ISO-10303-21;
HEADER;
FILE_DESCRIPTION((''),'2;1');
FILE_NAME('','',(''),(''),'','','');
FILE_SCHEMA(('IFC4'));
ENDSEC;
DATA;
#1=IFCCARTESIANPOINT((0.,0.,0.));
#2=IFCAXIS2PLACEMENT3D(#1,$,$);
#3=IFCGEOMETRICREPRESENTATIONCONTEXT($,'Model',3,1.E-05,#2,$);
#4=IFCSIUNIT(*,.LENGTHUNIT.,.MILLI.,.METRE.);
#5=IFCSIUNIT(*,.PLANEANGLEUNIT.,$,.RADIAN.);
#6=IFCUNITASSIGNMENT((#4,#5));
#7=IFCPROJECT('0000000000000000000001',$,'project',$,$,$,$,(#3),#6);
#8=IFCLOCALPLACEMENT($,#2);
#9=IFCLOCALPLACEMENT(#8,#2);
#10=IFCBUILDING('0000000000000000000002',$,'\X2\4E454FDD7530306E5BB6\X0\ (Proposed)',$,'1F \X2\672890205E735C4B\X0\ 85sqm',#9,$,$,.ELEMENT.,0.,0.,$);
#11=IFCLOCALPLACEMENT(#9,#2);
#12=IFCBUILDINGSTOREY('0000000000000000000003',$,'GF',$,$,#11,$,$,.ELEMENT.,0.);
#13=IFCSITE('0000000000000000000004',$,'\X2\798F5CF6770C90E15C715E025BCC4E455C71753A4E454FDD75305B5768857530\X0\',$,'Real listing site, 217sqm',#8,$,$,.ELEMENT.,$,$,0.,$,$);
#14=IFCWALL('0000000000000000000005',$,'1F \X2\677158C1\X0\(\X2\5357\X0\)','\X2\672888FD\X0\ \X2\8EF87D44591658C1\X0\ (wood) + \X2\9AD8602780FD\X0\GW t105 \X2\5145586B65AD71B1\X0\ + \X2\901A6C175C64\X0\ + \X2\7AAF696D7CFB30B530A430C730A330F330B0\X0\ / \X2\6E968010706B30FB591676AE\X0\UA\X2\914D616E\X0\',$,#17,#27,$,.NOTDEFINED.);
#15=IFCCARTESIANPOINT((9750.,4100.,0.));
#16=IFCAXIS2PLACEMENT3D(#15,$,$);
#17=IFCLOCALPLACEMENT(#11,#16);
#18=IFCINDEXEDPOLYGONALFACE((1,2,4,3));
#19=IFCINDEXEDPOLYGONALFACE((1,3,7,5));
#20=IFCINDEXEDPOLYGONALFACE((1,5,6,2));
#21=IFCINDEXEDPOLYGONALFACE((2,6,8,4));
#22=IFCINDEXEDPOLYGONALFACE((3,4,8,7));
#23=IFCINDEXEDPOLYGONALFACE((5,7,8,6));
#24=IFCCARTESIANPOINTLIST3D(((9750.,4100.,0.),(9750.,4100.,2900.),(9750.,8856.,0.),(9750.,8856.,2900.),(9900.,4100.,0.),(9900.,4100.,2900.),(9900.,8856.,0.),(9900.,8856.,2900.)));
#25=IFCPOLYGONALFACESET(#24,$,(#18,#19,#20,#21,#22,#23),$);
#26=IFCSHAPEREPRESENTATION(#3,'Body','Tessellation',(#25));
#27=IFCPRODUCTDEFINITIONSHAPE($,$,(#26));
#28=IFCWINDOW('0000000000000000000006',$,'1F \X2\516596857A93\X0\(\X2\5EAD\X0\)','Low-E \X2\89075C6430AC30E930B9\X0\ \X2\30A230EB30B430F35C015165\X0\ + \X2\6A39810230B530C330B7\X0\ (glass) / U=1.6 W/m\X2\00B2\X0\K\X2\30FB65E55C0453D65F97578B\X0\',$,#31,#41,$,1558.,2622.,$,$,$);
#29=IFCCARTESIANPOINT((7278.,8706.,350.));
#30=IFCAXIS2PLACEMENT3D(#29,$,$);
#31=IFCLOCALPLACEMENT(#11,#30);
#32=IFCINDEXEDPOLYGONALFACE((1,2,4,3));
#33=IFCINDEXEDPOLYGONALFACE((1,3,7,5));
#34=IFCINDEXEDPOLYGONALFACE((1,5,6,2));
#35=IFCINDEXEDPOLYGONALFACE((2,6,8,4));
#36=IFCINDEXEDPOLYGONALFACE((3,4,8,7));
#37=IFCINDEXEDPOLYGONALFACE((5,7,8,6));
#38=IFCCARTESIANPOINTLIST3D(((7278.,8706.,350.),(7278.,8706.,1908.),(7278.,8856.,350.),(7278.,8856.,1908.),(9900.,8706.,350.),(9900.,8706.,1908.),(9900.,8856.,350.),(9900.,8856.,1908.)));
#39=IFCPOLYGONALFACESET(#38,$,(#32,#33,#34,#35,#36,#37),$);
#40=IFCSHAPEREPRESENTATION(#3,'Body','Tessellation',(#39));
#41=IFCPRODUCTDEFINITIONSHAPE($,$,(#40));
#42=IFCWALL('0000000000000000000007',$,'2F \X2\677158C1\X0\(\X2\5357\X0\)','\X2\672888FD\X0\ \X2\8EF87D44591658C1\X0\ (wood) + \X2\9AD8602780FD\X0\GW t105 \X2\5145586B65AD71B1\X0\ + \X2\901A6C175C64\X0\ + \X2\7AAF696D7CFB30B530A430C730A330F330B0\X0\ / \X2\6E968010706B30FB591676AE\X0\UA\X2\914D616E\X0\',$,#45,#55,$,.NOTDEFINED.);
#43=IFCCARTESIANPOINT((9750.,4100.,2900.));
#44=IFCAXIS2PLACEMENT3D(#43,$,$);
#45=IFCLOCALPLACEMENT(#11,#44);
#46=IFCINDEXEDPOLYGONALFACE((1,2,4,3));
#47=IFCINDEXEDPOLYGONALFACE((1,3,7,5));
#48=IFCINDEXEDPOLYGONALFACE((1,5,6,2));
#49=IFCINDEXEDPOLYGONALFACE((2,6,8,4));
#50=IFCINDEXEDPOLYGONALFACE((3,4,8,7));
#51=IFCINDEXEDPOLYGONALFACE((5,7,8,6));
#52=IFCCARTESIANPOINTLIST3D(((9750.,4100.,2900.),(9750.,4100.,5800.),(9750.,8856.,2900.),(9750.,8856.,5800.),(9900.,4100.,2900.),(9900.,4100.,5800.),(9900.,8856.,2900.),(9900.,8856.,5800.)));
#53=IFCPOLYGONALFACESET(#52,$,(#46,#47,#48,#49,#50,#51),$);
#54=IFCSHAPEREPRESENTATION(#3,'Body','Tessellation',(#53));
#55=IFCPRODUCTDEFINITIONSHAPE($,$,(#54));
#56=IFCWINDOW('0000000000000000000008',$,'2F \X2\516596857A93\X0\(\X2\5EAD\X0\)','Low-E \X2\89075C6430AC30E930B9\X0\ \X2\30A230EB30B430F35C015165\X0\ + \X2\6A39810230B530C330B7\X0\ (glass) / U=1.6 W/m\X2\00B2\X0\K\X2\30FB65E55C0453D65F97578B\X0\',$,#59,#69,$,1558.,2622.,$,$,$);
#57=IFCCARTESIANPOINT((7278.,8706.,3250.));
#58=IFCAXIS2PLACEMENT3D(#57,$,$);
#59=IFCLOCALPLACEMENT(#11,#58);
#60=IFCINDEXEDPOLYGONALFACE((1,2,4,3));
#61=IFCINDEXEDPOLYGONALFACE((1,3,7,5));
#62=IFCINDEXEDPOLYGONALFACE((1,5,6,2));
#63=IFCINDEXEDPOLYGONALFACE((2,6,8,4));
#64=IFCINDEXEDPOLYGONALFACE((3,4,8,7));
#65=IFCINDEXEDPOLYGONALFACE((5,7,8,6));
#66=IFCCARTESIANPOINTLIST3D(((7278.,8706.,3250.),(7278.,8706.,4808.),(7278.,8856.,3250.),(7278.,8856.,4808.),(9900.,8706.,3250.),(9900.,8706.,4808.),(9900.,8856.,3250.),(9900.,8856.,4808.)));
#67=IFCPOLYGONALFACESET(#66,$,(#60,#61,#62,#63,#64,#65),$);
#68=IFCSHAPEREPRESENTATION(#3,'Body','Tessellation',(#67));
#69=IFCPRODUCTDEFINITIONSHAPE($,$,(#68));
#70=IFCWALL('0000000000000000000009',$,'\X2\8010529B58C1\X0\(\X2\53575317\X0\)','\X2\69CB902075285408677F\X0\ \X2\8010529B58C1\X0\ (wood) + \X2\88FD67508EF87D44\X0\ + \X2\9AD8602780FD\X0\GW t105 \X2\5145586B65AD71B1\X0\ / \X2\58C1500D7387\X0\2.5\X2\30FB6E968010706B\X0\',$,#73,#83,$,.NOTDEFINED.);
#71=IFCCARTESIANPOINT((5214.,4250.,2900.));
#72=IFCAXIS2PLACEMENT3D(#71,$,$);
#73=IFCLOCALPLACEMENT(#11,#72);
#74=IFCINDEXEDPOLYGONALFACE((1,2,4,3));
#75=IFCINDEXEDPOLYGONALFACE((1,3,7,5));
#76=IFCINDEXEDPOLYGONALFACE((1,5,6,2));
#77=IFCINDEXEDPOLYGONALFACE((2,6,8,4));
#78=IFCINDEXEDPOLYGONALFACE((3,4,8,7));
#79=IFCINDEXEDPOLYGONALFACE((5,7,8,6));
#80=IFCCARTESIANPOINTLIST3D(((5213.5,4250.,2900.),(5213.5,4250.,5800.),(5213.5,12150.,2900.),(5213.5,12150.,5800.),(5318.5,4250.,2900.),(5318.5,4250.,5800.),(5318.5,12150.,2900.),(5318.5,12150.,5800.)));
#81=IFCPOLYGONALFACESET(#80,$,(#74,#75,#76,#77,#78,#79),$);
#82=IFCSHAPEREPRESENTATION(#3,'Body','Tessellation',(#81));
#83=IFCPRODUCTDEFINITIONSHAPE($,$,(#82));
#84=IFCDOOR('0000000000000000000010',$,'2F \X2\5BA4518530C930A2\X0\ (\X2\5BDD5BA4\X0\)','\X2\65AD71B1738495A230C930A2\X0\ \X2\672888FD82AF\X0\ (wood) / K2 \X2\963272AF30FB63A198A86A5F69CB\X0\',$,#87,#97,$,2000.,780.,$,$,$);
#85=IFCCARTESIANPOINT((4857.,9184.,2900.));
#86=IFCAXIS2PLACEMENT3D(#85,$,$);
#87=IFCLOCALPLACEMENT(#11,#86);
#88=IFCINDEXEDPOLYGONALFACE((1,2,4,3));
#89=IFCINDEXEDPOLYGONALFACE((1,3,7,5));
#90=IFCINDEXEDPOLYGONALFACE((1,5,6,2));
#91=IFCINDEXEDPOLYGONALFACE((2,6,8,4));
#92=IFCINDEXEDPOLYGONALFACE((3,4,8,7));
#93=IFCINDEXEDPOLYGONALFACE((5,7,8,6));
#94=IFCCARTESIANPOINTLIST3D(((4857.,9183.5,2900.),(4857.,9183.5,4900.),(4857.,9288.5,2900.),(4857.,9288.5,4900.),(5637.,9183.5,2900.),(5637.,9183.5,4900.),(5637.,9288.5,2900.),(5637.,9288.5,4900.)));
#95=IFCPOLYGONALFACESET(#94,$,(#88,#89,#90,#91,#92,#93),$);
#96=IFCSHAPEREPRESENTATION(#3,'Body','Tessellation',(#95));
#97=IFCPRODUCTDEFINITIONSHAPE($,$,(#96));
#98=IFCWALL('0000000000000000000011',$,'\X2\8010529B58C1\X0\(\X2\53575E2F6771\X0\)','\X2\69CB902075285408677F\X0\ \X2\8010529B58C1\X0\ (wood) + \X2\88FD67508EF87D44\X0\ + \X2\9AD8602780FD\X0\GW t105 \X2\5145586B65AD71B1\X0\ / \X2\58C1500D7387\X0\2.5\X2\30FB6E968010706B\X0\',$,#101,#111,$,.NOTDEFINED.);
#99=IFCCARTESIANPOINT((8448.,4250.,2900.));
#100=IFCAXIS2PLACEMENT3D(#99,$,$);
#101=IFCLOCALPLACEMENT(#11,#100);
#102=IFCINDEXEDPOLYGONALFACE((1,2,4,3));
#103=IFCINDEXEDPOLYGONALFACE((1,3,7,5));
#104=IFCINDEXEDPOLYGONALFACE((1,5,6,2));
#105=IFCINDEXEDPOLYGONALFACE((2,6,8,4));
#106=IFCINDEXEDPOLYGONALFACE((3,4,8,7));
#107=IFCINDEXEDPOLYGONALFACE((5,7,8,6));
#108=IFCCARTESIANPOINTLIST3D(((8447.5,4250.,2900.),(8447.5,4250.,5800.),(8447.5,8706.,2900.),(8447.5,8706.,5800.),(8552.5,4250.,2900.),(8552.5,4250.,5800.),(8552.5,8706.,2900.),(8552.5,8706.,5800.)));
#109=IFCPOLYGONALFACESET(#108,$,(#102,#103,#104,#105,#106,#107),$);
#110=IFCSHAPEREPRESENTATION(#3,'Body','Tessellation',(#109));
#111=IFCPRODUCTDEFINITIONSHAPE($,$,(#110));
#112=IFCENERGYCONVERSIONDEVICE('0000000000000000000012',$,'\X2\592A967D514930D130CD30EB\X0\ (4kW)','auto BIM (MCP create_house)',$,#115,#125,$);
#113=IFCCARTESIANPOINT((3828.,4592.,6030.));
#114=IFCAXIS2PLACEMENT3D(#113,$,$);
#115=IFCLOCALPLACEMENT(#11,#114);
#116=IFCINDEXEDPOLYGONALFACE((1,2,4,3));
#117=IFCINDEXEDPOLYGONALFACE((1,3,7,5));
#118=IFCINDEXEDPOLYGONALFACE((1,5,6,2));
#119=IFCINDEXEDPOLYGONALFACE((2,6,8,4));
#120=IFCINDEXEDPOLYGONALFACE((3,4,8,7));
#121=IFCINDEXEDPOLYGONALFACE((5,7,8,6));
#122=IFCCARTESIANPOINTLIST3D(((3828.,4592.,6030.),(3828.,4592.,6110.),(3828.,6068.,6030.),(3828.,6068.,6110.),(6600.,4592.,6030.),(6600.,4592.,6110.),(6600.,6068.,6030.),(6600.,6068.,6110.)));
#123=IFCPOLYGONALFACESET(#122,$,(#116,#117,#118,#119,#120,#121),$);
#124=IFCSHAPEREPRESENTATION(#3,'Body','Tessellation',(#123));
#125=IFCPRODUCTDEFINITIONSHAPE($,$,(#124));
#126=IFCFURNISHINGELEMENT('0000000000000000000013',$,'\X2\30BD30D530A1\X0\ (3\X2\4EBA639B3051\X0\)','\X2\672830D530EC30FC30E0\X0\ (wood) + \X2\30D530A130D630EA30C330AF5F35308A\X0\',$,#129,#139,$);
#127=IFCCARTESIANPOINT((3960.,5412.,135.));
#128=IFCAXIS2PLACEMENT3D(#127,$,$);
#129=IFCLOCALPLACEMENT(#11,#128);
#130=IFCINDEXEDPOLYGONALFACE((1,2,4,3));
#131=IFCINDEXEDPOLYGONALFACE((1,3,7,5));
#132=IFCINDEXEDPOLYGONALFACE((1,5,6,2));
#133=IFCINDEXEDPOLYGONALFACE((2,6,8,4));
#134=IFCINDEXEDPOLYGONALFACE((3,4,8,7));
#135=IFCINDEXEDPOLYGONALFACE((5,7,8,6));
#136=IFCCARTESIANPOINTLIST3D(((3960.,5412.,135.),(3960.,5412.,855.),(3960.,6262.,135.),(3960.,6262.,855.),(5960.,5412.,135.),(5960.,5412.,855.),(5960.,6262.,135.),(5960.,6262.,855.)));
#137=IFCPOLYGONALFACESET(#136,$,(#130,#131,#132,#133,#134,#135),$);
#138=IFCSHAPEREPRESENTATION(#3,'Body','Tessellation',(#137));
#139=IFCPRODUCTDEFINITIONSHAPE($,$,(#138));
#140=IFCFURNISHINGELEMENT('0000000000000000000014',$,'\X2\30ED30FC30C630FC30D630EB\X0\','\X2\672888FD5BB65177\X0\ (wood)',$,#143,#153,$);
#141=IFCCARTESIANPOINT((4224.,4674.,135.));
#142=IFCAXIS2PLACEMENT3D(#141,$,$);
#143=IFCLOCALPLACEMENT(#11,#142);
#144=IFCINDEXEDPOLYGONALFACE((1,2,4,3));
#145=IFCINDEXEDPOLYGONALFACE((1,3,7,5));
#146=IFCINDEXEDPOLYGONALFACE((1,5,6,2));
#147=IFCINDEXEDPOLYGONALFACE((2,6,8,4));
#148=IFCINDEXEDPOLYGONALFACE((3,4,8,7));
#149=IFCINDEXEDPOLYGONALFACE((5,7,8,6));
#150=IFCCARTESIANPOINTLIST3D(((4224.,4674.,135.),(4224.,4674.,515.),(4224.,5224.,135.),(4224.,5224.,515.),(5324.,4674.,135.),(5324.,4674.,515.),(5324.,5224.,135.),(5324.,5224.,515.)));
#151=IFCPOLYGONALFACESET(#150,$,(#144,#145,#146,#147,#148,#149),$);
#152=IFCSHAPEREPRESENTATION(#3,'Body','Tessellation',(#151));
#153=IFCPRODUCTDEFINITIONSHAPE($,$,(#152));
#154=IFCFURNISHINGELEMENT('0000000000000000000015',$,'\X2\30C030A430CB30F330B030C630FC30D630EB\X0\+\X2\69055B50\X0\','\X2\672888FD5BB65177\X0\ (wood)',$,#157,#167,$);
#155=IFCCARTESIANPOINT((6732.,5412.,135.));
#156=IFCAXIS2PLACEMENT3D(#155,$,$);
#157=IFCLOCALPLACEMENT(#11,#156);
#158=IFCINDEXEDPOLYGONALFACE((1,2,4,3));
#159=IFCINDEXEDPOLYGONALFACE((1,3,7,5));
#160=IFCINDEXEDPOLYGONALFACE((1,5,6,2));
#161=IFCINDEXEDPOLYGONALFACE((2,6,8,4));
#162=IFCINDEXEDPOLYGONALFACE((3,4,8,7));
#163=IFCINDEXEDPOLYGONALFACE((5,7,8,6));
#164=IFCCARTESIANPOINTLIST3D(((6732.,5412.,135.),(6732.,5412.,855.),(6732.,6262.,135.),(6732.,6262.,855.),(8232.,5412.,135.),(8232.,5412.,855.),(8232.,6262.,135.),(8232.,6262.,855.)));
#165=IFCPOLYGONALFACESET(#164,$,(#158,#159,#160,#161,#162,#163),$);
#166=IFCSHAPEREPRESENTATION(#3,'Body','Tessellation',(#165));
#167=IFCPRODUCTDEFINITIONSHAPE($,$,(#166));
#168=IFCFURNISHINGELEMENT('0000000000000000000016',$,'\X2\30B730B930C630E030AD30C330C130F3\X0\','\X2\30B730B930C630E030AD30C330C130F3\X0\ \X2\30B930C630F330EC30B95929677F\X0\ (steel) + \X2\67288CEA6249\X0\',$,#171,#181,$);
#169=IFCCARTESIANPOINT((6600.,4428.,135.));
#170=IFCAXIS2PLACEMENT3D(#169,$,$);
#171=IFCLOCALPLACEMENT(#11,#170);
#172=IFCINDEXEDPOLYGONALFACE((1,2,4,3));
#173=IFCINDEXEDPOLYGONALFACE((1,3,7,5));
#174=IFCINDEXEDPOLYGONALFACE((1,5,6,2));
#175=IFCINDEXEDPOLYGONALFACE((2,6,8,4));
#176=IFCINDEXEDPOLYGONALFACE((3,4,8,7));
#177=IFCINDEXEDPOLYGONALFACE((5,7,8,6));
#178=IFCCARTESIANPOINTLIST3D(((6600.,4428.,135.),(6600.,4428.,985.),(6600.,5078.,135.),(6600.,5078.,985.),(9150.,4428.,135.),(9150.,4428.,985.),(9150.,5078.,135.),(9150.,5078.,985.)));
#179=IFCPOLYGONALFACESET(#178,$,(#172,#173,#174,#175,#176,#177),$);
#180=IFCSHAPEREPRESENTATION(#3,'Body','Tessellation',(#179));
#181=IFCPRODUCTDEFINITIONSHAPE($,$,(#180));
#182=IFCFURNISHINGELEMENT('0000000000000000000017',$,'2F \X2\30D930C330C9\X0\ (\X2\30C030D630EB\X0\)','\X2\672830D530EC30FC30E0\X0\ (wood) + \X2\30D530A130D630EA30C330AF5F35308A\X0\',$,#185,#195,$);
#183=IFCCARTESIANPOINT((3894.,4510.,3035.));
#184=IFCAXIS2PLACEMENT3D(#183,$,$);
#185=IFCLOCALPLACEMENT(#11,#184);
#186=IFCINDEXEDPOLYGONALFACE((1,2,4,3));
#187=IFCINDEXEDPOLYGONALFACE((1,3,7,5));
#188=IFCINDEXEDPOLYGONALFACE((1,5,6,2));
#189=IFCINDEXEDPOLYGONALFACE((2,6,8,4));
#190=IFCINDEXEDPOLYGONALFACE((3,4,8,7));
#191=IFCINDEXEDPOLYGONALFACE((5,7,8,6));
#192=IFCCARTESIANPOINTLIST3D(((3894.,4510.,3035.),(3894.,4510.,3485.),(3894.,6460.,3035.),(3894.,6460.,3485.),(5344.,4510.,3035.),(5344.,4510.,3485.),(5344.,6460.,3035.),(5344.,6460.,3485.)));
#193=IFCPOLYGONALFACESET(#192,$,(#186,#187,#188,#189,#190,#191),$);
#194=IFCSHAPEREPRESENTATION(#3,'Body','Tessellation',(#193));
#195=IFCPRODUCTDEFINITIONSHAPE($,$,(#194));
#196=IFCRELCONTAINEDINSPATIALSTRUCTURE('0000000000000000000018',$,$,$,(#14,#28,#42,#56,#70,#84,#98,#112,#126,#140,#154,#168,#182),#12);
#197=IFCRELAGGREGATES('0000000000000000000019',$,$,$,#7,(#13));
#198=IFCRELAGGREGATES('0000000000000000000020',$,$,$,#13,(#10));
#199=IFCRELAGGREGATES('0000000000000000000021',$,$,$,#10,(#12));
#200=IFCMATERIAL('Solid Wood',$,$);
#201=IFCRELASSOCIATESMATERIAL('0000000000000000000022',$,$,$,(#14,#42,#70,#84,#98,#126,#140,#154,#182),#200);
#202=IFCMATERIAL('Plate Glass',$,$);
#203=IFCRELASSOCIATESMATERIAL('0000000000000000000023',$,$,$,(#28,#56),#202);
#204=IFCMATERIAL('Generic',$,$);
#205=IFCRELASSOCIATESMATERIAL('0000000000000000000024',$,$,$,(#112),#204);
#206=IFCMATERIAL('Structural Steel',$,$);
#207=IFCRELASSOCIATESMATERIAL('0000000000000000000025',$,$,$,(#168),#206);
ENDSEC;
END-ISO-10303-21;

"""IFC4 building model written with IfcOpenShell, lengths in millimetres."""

from ifc_helpers import new_model, si_unit, frame, frame_2d, origin, place, context, project, spatial, rectangle, extrude, material, element, fill, save


model = new_model("IFC4")

# Units and contexts
model_context = context("Model", 3, precision=1e-05, world=origin())
ifc_project = project(units=[si_unit("LENGTHUNIT", "METRE", prefix="MILLI"), si_unit("PLANEANGLEUNIT", "RADIAN")], contexts=[model_context])

# Site, building, storey
site_placement = place(None, origin())
site = spatial("IfcSite", under=ifc_project, at=site_placement, Name="福島県郡山市富久山町久保田字梅田", ObjectType="Real listing site, 217sqm", CompositionType="ELEMENT", RefElevation=0.0)
building_placement = place(site_placement, origin())
building = spatial("IfcBuilding", under=site, at=building_placement, Name="久保田の家 (Proposed)", ObjectType="1F 木造平屋 85sqm", CompositionType="ELEMENT", ElevationOfRefHeight=0.0, ElevationOfTerrain=0.0)
storey_placement = place(building_placement, origin())
storey = spatial("IfcBuildingStorey", under=building, at=storey_placement, Name="GF", CompositionType="ELEMENT", Elevation=0.0)

# Wall, opening, window
ifc_material_1 = material(Name="Solid Wood")
wall_1_placement = place(storey_placement, frame((9750.0, 4100.0, 0.0)))
wall_1 = element("IfcWall", 1, at=wall_1_placement, inside=storey, material=ifc_material_1, Name="1F 東壁(南)", Description="木製 軸組外壁 (wood) + 高性能GW t105 充填断熱 + 通気層 + 窯業系サイディング / 準耐火・外皮UA配慮", PredefinedType="NOTDEFINED", context=model_context, shape_type="SweptSolid", body=[
    extrude(rectangle(XDim=150.0, YDim=4756.0, at=frame_2d((75.0, 2378.0))), frame((9750.0, 4100.0, 0.0)), (0.0, 0.0, 1.0), 2900.0),
])
opening_1_placement = place(storey_placement, frame((7278.0, 8706.0, 350.0)))
opening_1 = element("IfcOpeningElement", 2, at=opening_1_placement, cuts=wall_1, PredefinedType="NOTDEFINED", context=model_context, shape_type="SweptSolid", body=[
    extrude(rectangle(XDim=2622.0, YDim=150.0, at=frame_2d((1311.0, 75.0))), frame((7278.0, 8706.0, 350.0)), (0.0, 0.0, 1.0), 1558.0),
])
ifc_material_2 = material(Name="Plate Glass")
window_1_placement = place(storey_placement, frame((7278.0, 8706.0, 350.0)))
window_1 = element("IfcWindow", 3, at=window_1_placement, inside=storey, material=ifc_material_2, Name="1F 入隅窓(庭)", Description="Low-E 複層ガラス アルゴン封入 + 樹脂サッシ (glass) / U=1.6 W/m²K・日射取得型", OverallHeight=1558.0, OverallWidth=2622.0, context=model_context, shape_type="SweptSolid", body=[
    extrude(rectangle(XDim=2622.0, YDim=150.0, at=frame_2d((1311.0, 75.0))), frame((7278.0, 8706.0, 350.0)), (0.0, 0.0, 1.0), 1558.0),
])
fill(opening_1, window_1)

# Wall, opening, window
wall_2_placement = place(storey_placement, frame((9750.0, 4100.0, 2900.0)))
wall_2 = element("IfcWall", 4, at=wall_2_placement, inside=storey, material=ifc_material_1, Name="2F 東壁(南)", Description="木製 軸組外壁 (wood) + 高性能GW t105 充填断熱 + 通気層 + 窯業系サイディング / 準耐火・外皮UA配慮", PredefinedType="NOTDEFINED", context=model_context, shape_type="SweptSolid", body=[
    extrude(rectangle(XDim=150.0, YDim=4756.0, at=frame_2d((75.0, 2378.0))), frame((9750.0, 4100.0, 2900.0)), (0.0, 0.0, 1.0), 2900.0),
])
opening_2_placement = place(storey_placement, frame((7278.0, 8706.0, 3250.0)))
opening_2 = element("IfcOpeningElement", 5, at=opening_2_placement, cuts=wall_2, PredefinedType="NOTDEFINED", context=model_context, shape_type="SweptSolid", body=[
    extrude(rectangle(XDim=2622.0, YDim=150.0, at=frame_2d((1311.0, 75.0))), frame((7278.0, 8706.0, 3250.0)), (0.0, 0.0, 1.0), 1558.0),
])
window_2_placement = place(storey_placement, frame((7278.0, 8706.0, 3250.0)))
window_2 = element("IfcWindow", 6, at=window_2_placement, inside=storey, material=ifc_material_2, Name="2F 入隅窓(庭)", Description="Low-E 複層ガラス アルゴン封入 + 樹脂サッシ (glass) / U=1.6 W/m²K・日射取得型", OverallHeight=1558.0, OverallWidth=2622.0, context=model_context, shape_type="SweptSolid", body=[
    extrude(rectangle(XDim=2622.0, YDim=150.0, at=frame_2d((1311.0, 75.0))), frame((7278.0, 8706.0, 3250.0)), (0.0, 0.0, 1.0), 1558.0),
])
fill(opening_2, window_2)

# Wall, opening, door
wall_3_placement = place(storey_placement, frame((5214.0, 4250.0, 2900.0)))
wall_3 = element("IfcWall", 7, at=wall_3_placement, inside=storey, material=ifc_material_1, Name="耐力壁(南北)", Description="構造用合板 耐力壁 (wood) + 製材軸組 + 高性能GW t105 充填断熱 / 壁倍率2.5・準耐火", PredefinedType="NOTDEFINED", context=model_context, shape_type="SweptSolid", body=[
    extrude(rectangle(XDim=105.0, YDim=7900.0, at=frame_2d((52.0, 3950.0))), frame((5214.0, 4250.0, 2900.0)), (0.0, 0.0, 1.0), 2900.0),
])
opening_3_placement = place(storey_placement, frame((4857.0, 9184.0, 2900.0)))
opening_3 = element("IfcOpeningElement", 8, at=opening_3_placement, cuts=wall_3, PredefinedType="NOTDEFINED", context=model_context, shape_type="SweptSolid", body=[
    extrude(rectangle(XDim=780.0, YDim=105.0, at=frame_2d((390.0, 52.0))), frame((4857.0, 9184.0, 2900.0)), (0.0, 0.0, 1.0), 2000.0),
])
door_1_placement = place(storey_placement, frame((4857.0, 9184.0, 2900.0)))
door_1 = element("IfcDoor", 9, at=door_1_placement, inside=storey, material=ifc_material_1, Name="2F 室内ドア (寝室)", Description="断熱玄関ドア 木製芯 (wood) / K2 防犯・採風機構", OverallHeight=2000.0, OverallWidth=780.0, context=model_context, shape_type="SweptSolid", body=[
    extrude(rectangle(XDim=780.0, YDim=105.0, at=frame_2d((390.0, 52.0))), frame((4857.0, 9184.0, 2900.0)), (0.0, 0.0, 1.0), 2000.0),
])
fill(opening_3, door_1)

# Wall
wall_4_placement = place(storey_placement, frame((8448.0, 4250.0, 2900.0)))
element("IfcWall", 10, at=wall_4_placement, inside=storey, material=ifc_material_1, Name="耐力壁(南帯東)", Description="構造用合板 耐力壁 (wood) + 製材軸組 + 高性能GW t105 充填断熱 / 壁倍率2.5・準耐火", PredefinedType="NOTDEFINED", context=model_context, shape_type="SweptSolid", body=[
    extrude(rectangle(XDim=105.0, YDim=4456.0, at=frame_2d((52.0, 2228.0))), frame((8448.0, 4250.0, 2900.0)), (0.0, 0.0, 1.0), 2900.0),
])

# Energy conversion device
ifc_material_3 = material(Name="Generic")
energy_conversion_device_placement = place(storey_placement, frame((3828.0, 4592.0, 6030.0)))
element("IfcEnergyConversionDevice", 11, at=energy_conversion_device_placement, inside=storey, material=ifc_material_3, Name="太陽光パネル (4kW)", Description="auto BIM (MCP create_house)", context=model_context, shape_type="SweptSolid", body=[
    extrude(rectangle(XDim=2772.0, YDim=1476.0, at=frame_2d((1386.0, 738.0))), frame((3828.0, 4592.0, 6030.0)), (0.0, 0.0, 1.0), 80.0),
])

# Furnishing elements
furnishing_1_placement = place(storey_placement, frame((3960.0, 5412.0, 135.0)))
element("IfcFurnishingElement", 12, at=furnishing_1_placement, inside=storey, material=ifc_material_1, Name="ソファ (3人掛け)", Description="木フレーム (wood) + ファブリック張り", context=model_context, shape_type="SweptSolid", body=[
    extrude(rectangle(XDim=2000.0, YDim=850.0, at=frame_2d((1000.0, 425.0))), frame((3960.0, 5412.0, 135.0)), (0.0, 0.0, 1.0), 720.0),
])
furnishing_2_placement = place(storey_placement, frame((4224.0, 4674.0, 135.0)))
element("IfcFurnishingElement", 13, at=furnishing_2_placement, inside=storey, material=ifc_material_1, Name="ローテーブル", Description="木製家具 (wood)", context=model_context, shape_type="SweptSolid", body=[
    extrude(rectangle(XDim=1100.0, YDim=550.0, at=frame_2d((550.0, 275.0))), frame((4224.0, 4674.0, 135.0)), (0.0, 0.0, 1.0), 380.0),
])
furnishing_3_placement = place(storey_placement, frame((6732.0, 5412.0, 135.0)))
element("IfcFurnishingElement", 14, at=furnishing_3_placement, inside=storey, material=ifc_material_1, Name="ダイニングテーブル+椅子", Description="木製家具 (wood)", context=model_context, shape_type="SweptSolid", body=[
    extrude(rectangle(XDim=1500.0, YDim=850.0, at=frame_2d((750.0, 425.0))), frame((6732.0, 5412.0, 135.0)), (0.0, 0.0, 1.0), 720.0),
])
ifc_material_4 = material(Name="Structural Steel")
furnishing_4_placement = place(storey_placement, frame((6600.0, 4428.0, 135.0)))
element("IfcFurnishingElement", 15, at=furnishing_4_placement, inside=storey, material=ifc_material_4, Name="システムキッチン", Description="システムキッチン ステンレス天板 (steel) + 木質扉", context=model_context, shape_type="SweptSolid", body=[
    extrude(rectangle(XDim=2550.0, YDim=650.0, at=frame_2d((1275.0, 325.0))), frame((6600.0, 4428.0, 135.0)), (0.0, 0.0, 1.0), 850.0),
])
furnishing_5_placement = place(storey_placement, frame((3894.0, 4510.0, 3035.0)))
element("IfcFurnishingElement", 16, at=furnishing_5_placement, inside=storey, material=ifc_material_1, Name="2F ベッド (ダブル)", Description="木フレーム (wood) + ファブリック張り", context=model_context, shape_type="SweptSolid", body=[
    extrude(rectangle(XDim=1450.0, YDim=1950.0, at=frame_2d((725.0, 975.0))), frame((3894.0, 4510.0, 3035.0)), (0.0, 0.0, 1.0), 450.0),
])

save(model, "model.ifc")
